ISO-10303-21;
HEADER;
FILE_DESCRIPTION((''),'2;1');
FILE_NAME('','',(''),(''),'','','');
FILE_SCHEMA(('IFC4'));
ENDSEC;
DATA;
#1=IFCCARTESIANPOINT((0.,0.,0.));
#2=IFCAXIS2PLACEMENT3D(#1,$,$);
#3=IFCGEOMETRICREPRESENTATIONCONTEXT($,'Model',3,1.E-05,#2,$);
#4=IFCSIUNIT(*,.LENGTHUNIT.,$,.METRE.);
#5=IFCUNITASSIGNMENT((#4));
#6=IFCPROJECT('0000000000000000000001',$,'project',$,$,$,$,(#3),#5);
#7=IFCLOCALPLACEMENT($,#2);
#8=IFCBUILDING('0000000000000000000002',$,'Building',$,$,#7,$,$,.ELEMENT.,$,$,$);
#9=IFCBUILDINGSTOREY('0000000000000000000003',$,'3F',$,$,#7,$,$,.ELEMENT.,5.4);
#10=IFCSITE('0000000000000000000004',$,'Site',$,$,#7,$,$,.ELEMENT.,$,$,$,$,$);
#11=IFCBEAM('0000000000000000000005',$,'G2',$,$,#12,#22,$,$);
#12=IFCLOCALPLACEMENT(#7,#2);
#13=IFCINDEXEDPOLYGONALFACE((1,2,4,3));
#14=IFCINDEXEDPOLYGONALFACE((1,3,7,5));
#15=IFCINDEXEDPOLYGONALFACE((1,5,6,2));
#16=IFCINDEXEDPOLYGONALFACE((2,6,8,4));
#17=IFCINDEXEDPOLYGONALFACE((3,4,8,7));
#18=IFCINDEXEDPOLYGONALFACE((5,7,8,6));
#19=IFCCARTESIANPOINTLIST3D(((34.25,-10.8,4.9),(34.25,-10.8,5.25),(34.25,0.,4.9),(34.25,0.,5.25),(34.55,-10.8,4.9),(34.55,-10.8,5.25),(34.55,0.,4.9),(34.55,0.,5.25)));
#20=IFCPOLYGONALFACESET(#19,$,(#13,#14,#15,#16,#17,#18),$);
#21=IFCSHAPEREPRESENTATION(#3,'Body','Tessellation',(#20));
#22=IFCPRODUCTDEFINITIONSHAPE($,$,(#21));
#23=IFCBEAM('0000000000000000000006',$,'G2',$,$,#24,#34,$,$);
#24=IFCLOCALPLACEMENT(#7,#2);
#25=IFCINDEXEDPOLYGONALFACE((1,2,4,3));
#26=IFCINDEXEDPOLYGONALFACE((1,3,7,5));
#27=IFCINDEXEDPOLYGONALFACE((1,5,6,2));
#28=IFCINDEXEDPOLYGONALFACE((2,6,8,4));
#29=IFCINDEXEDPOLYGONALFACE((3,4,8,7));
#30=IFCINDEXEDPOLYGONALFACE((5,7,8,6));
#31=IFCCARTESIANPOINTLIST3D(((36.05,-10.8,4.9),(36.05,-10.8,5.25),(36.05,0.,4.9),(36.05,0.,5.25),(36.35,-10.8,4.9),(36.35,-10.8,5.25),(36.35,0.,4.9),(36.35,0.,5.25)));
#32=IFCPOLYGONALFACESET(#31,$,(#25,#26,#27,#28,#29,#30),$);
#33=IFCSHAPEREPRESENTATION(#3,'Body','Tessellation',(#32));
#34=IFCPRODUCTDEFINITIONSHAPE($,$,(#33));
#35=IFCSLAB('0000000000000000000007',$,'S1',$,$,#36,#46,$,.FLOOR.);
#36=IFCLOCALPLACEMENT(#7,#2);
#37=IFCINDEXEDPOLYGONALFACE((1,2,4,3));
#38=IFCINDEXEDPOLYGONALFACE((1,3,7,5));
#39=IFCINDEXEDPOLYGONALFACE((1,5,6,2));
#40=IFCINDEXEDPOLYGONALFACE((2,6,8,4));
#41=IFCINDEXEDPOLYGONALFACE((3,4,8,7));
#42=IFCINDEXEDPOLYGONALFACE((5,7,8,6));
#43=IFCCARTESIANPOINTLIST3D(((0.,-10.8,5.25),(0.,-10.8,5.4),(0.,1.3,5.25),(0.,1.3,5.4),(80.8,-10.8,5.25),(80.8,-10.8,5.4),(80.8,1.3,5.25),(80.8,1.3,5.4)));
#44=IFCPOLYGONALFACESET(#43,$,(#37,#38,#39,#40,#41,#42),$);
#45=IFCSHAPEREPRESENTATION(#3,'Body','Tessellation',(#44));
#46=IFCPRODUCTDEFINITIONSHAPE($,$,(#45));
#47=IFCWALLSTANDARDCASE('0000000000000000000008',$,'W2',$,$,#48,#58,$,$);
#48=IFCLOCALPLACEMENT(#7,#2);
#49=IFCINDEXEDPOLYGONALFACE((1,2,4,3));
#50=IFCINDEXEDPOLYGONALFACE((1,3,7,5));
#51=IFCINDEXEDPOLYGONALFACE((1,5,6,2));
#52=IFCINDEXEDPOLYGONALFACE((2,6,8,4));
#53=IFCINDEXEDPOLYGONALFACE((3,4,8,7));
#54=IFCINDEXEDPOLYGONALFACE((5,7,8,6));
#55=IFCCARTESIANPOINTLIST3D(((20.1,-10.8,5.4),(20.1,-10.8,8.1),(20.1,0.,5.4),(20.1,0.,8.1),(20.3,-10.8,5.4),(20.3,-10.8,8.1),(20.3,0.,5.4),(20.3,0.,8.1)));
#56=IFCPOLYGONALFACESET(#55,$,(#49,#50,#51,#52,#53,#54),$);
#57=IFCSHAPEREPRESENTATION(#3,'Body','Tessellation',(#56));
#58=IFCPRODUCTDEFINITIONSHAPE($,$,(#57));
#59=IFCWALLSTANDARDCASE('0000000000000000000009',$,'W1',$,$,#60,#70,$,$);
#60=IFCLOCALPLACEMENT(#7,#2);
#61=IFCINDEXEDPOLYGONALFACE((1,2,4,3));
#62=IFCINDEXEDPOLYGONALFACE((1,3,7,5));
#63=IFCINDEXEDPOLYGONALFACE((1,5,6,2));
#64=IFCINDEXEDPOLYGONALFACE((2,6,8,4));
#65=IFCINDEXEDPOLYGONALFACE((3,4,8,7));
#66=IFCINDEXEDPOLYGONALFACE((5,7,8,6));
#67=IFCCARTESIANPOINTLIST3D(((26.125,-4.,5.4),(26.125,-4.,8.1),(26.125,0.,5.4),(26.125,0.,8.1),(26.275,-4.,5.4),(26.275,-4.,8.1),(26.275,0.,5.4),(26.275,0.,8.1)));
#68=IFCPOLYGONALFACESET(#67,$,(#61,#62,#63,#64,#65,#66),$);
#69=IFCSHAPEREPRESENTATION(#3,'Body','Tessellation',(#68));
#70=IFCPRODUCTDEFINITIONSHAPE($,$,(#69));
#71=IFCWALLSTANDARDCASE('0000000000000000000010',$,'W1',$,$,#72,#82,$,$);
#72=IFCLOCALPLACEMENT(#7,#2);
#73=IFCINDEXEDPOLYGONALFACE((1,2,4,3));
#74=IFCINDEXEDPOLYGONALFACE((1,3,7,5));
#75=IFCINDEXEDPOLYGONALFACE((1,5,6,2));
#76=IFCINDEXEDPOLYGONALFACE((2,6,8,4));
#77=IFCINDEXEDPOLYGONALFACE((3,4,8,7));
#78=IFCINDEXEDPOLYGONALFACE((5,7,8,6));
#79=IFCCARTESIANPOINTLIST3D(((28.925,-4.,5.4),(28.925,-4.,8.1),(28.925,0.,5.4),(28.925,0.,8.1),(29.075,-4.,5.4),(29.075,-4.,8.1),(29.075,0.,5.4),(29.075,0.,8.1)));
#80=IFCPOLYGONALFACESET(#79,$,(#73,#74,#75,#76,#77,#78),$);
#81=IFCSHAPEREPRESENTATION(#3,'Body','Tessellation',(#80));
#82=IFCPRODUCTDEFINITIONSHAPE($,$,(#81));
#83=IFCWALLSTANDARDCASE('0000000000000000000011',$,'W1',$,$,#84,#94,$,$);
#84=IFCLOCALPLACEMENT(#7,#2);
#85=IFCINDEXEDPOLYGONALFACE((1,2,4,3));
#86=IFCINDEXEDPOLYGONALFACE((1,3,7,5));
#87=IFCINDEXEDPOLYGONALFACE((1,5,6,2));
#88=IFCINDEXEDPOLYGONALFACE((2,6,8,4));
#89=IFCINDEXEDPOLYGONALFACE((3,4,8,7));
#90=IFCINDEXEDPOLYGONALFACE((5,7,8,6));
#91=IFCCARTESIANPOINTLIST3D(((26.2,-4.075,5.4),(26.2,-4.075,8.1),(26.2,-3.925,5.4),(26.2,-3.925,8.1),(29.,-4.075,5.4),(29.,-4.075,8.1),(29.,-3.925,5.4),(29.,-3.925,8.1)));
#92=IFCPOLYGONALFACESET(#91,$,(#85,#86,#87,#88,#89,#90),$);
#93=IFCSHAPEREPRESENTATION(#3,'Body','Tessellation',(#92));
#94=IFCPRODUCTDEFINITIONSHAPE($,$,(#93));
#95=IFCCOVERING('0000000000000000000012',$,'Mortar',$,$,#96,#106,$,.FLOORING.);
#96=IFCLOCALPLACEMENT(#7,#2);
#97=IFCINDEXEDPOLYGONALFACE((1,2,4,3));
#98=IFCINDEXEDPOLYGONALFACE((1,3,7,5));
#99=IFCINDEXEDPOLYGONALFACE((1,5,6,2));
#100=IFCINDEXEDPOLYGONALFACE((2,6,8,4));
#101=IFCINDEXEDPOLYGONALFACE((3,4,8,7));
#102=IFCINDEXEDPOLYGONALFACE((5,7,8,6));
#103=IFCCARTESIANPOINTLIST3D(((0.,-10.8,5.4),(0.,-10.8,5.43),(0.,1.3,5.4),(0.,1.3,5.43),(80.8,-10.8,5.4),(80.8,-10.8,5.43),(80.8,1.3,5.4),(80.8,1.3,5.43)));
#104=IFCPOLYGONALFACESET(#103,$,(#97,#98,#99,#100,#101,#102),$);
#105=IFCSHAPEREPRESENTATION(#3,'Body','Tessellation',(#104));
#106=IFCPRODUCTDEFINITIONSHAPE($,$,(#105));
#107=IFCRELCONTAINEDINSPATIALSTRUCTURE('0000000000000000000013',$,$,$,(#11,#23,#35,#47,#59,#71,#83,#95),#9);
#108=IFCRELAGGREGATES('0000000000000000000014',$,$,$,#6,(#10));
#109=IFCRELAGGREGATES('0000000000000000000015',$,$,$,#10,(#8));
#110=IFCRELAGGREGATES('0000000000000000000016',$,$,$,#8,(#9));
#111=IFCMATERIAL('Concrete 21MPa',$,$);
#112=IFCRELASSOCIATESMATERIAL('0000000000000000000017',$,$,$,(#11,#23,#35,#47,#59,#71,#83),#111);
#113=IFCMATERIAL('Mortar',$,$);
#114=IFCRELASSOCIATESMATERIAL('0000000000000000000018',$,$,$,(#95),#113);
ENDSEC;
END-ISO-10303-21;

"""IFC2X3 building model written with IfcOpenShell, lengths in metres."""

from ifc_helpers import new_model, si_unit, frame, origin, origin_2d, place, context, project, spatial, rectangle, extrude, material, element, save


model = new_model("IFC2X3")

# Units and contexts
model_context = context("Model", 3, precision=1e-05, world=origin())
ifc_project = project(units=[si_unit("LENGTHUNIT", "METRE")], contexts=[model_context])

# Site, building, storey
placement = place(None, origin())
site = spatial("IfcSite", under=ifc_project, at=placement, Name="Site", CompositionType="ELEMENT")
building = spatial("IfcBuilding", under=site, at=placement, Name="Building", CompositionType="ELEMENT")
storey = spatial("IfcBuildingStorey", under=building, at=placement, Name="3F", CompositionType="ELEMENT", Elevation=5.4)

# Shared definitions
ifc_material_1 = material(Name="Concrete 21MPa")

# Beams
for number, where, name in (
    (1, (34.4, -5.4, 4.9), "G2"),
    (2, (36.2, -5.4, 4.9), "G2"),
):
    element("IfcBeam", number, at=place(None, frame(where)), inside=storey, material=ifc_material_1, Name=name, context=model_context, shape_type="SweptSolid", body=[
        extrude(rectangle(XDim=0.3, YDim=10.8, at=origin_2d()), origin(), (0.0, 0.0, 1.0), 0.35),
    ])

# Slab
slab_placement = place(None, frame((40.4, -4.75, 5.25)))
element("IfcSlab", 3, at=slab_placement, inside=storey, material=ifc_material_1, Name="S1", PredefinedType="FLOOR", context=model_context, shape_type="SweptSolid", body=[
    extrude(rectangle(XDim=80.8, YDim=12.1, at=origin_2d()), origin(), (0.0, 0.0, 1.0), 0.15),
])

# Walls
wall_1_placement = place(None, frame((20.2, -5.4, 5.4)))
element("IfcWallStandardCase", 4, at=wall_1_placement, inside=storey, material=ifc_material_1, Name="W2", context=model_context, shape_type="SweptSolid", body=[
    extrude(rectangle(XDim=0.2, YDim=10.8, at=origin_2d()), origin(), (0.0, 0.0, 1.0), 2.7),
])
for number, where, name in (
    (5, (26.2, -2.0, 5.4), "W1"),
    (6, (29.0, -2.0, 5.4), "W1"),
):
    element("IfcWallStandardCase", number, at=place(None, frame(where)), inside=storey, material=ifc_material_1, Name=name, context=model_context, shape_type="SweptSolid", body=[
        extrude(rectangle(XDim=0.15, YDim=4.0, at=origin_2d()), origin(), (0.0, 0.0, 1.0), 2.7),
    ])
wall_2_placement = place(None, frame((27.6, -4.0, 5.4)))
element("IfcWallStandardCase", 7, at=wall_2_placement, inside=storey, material=ifc_material_1, Name="W1", context=model_context, shape_type="SweptSolid", body=[
    extrude(rectangle(XDim=2.8, YDim=0.15, at=origin_2d()), origin(), (0.0, 0.0, 1.0), 2.7),
])

# Covering
ifc_material_2 = material(Name="Mortar")
covering_placement = place(None, frame((40.4, -4.75, 5.4)))
element("IfcCovering", 8, at=covering_placement, inside=storey, material=ifc_material_2, Name="Mortar", PredefinedType="FLOORING", context=model_context, shape_type="SweptSolid", body=[
    extrude(rectangle(XDim=80.8, YDim=12.1, at=origin_2d()), origin(), (0.0, 0.0, 1.0), 0.03),
])

save(model, "model.ifc")
